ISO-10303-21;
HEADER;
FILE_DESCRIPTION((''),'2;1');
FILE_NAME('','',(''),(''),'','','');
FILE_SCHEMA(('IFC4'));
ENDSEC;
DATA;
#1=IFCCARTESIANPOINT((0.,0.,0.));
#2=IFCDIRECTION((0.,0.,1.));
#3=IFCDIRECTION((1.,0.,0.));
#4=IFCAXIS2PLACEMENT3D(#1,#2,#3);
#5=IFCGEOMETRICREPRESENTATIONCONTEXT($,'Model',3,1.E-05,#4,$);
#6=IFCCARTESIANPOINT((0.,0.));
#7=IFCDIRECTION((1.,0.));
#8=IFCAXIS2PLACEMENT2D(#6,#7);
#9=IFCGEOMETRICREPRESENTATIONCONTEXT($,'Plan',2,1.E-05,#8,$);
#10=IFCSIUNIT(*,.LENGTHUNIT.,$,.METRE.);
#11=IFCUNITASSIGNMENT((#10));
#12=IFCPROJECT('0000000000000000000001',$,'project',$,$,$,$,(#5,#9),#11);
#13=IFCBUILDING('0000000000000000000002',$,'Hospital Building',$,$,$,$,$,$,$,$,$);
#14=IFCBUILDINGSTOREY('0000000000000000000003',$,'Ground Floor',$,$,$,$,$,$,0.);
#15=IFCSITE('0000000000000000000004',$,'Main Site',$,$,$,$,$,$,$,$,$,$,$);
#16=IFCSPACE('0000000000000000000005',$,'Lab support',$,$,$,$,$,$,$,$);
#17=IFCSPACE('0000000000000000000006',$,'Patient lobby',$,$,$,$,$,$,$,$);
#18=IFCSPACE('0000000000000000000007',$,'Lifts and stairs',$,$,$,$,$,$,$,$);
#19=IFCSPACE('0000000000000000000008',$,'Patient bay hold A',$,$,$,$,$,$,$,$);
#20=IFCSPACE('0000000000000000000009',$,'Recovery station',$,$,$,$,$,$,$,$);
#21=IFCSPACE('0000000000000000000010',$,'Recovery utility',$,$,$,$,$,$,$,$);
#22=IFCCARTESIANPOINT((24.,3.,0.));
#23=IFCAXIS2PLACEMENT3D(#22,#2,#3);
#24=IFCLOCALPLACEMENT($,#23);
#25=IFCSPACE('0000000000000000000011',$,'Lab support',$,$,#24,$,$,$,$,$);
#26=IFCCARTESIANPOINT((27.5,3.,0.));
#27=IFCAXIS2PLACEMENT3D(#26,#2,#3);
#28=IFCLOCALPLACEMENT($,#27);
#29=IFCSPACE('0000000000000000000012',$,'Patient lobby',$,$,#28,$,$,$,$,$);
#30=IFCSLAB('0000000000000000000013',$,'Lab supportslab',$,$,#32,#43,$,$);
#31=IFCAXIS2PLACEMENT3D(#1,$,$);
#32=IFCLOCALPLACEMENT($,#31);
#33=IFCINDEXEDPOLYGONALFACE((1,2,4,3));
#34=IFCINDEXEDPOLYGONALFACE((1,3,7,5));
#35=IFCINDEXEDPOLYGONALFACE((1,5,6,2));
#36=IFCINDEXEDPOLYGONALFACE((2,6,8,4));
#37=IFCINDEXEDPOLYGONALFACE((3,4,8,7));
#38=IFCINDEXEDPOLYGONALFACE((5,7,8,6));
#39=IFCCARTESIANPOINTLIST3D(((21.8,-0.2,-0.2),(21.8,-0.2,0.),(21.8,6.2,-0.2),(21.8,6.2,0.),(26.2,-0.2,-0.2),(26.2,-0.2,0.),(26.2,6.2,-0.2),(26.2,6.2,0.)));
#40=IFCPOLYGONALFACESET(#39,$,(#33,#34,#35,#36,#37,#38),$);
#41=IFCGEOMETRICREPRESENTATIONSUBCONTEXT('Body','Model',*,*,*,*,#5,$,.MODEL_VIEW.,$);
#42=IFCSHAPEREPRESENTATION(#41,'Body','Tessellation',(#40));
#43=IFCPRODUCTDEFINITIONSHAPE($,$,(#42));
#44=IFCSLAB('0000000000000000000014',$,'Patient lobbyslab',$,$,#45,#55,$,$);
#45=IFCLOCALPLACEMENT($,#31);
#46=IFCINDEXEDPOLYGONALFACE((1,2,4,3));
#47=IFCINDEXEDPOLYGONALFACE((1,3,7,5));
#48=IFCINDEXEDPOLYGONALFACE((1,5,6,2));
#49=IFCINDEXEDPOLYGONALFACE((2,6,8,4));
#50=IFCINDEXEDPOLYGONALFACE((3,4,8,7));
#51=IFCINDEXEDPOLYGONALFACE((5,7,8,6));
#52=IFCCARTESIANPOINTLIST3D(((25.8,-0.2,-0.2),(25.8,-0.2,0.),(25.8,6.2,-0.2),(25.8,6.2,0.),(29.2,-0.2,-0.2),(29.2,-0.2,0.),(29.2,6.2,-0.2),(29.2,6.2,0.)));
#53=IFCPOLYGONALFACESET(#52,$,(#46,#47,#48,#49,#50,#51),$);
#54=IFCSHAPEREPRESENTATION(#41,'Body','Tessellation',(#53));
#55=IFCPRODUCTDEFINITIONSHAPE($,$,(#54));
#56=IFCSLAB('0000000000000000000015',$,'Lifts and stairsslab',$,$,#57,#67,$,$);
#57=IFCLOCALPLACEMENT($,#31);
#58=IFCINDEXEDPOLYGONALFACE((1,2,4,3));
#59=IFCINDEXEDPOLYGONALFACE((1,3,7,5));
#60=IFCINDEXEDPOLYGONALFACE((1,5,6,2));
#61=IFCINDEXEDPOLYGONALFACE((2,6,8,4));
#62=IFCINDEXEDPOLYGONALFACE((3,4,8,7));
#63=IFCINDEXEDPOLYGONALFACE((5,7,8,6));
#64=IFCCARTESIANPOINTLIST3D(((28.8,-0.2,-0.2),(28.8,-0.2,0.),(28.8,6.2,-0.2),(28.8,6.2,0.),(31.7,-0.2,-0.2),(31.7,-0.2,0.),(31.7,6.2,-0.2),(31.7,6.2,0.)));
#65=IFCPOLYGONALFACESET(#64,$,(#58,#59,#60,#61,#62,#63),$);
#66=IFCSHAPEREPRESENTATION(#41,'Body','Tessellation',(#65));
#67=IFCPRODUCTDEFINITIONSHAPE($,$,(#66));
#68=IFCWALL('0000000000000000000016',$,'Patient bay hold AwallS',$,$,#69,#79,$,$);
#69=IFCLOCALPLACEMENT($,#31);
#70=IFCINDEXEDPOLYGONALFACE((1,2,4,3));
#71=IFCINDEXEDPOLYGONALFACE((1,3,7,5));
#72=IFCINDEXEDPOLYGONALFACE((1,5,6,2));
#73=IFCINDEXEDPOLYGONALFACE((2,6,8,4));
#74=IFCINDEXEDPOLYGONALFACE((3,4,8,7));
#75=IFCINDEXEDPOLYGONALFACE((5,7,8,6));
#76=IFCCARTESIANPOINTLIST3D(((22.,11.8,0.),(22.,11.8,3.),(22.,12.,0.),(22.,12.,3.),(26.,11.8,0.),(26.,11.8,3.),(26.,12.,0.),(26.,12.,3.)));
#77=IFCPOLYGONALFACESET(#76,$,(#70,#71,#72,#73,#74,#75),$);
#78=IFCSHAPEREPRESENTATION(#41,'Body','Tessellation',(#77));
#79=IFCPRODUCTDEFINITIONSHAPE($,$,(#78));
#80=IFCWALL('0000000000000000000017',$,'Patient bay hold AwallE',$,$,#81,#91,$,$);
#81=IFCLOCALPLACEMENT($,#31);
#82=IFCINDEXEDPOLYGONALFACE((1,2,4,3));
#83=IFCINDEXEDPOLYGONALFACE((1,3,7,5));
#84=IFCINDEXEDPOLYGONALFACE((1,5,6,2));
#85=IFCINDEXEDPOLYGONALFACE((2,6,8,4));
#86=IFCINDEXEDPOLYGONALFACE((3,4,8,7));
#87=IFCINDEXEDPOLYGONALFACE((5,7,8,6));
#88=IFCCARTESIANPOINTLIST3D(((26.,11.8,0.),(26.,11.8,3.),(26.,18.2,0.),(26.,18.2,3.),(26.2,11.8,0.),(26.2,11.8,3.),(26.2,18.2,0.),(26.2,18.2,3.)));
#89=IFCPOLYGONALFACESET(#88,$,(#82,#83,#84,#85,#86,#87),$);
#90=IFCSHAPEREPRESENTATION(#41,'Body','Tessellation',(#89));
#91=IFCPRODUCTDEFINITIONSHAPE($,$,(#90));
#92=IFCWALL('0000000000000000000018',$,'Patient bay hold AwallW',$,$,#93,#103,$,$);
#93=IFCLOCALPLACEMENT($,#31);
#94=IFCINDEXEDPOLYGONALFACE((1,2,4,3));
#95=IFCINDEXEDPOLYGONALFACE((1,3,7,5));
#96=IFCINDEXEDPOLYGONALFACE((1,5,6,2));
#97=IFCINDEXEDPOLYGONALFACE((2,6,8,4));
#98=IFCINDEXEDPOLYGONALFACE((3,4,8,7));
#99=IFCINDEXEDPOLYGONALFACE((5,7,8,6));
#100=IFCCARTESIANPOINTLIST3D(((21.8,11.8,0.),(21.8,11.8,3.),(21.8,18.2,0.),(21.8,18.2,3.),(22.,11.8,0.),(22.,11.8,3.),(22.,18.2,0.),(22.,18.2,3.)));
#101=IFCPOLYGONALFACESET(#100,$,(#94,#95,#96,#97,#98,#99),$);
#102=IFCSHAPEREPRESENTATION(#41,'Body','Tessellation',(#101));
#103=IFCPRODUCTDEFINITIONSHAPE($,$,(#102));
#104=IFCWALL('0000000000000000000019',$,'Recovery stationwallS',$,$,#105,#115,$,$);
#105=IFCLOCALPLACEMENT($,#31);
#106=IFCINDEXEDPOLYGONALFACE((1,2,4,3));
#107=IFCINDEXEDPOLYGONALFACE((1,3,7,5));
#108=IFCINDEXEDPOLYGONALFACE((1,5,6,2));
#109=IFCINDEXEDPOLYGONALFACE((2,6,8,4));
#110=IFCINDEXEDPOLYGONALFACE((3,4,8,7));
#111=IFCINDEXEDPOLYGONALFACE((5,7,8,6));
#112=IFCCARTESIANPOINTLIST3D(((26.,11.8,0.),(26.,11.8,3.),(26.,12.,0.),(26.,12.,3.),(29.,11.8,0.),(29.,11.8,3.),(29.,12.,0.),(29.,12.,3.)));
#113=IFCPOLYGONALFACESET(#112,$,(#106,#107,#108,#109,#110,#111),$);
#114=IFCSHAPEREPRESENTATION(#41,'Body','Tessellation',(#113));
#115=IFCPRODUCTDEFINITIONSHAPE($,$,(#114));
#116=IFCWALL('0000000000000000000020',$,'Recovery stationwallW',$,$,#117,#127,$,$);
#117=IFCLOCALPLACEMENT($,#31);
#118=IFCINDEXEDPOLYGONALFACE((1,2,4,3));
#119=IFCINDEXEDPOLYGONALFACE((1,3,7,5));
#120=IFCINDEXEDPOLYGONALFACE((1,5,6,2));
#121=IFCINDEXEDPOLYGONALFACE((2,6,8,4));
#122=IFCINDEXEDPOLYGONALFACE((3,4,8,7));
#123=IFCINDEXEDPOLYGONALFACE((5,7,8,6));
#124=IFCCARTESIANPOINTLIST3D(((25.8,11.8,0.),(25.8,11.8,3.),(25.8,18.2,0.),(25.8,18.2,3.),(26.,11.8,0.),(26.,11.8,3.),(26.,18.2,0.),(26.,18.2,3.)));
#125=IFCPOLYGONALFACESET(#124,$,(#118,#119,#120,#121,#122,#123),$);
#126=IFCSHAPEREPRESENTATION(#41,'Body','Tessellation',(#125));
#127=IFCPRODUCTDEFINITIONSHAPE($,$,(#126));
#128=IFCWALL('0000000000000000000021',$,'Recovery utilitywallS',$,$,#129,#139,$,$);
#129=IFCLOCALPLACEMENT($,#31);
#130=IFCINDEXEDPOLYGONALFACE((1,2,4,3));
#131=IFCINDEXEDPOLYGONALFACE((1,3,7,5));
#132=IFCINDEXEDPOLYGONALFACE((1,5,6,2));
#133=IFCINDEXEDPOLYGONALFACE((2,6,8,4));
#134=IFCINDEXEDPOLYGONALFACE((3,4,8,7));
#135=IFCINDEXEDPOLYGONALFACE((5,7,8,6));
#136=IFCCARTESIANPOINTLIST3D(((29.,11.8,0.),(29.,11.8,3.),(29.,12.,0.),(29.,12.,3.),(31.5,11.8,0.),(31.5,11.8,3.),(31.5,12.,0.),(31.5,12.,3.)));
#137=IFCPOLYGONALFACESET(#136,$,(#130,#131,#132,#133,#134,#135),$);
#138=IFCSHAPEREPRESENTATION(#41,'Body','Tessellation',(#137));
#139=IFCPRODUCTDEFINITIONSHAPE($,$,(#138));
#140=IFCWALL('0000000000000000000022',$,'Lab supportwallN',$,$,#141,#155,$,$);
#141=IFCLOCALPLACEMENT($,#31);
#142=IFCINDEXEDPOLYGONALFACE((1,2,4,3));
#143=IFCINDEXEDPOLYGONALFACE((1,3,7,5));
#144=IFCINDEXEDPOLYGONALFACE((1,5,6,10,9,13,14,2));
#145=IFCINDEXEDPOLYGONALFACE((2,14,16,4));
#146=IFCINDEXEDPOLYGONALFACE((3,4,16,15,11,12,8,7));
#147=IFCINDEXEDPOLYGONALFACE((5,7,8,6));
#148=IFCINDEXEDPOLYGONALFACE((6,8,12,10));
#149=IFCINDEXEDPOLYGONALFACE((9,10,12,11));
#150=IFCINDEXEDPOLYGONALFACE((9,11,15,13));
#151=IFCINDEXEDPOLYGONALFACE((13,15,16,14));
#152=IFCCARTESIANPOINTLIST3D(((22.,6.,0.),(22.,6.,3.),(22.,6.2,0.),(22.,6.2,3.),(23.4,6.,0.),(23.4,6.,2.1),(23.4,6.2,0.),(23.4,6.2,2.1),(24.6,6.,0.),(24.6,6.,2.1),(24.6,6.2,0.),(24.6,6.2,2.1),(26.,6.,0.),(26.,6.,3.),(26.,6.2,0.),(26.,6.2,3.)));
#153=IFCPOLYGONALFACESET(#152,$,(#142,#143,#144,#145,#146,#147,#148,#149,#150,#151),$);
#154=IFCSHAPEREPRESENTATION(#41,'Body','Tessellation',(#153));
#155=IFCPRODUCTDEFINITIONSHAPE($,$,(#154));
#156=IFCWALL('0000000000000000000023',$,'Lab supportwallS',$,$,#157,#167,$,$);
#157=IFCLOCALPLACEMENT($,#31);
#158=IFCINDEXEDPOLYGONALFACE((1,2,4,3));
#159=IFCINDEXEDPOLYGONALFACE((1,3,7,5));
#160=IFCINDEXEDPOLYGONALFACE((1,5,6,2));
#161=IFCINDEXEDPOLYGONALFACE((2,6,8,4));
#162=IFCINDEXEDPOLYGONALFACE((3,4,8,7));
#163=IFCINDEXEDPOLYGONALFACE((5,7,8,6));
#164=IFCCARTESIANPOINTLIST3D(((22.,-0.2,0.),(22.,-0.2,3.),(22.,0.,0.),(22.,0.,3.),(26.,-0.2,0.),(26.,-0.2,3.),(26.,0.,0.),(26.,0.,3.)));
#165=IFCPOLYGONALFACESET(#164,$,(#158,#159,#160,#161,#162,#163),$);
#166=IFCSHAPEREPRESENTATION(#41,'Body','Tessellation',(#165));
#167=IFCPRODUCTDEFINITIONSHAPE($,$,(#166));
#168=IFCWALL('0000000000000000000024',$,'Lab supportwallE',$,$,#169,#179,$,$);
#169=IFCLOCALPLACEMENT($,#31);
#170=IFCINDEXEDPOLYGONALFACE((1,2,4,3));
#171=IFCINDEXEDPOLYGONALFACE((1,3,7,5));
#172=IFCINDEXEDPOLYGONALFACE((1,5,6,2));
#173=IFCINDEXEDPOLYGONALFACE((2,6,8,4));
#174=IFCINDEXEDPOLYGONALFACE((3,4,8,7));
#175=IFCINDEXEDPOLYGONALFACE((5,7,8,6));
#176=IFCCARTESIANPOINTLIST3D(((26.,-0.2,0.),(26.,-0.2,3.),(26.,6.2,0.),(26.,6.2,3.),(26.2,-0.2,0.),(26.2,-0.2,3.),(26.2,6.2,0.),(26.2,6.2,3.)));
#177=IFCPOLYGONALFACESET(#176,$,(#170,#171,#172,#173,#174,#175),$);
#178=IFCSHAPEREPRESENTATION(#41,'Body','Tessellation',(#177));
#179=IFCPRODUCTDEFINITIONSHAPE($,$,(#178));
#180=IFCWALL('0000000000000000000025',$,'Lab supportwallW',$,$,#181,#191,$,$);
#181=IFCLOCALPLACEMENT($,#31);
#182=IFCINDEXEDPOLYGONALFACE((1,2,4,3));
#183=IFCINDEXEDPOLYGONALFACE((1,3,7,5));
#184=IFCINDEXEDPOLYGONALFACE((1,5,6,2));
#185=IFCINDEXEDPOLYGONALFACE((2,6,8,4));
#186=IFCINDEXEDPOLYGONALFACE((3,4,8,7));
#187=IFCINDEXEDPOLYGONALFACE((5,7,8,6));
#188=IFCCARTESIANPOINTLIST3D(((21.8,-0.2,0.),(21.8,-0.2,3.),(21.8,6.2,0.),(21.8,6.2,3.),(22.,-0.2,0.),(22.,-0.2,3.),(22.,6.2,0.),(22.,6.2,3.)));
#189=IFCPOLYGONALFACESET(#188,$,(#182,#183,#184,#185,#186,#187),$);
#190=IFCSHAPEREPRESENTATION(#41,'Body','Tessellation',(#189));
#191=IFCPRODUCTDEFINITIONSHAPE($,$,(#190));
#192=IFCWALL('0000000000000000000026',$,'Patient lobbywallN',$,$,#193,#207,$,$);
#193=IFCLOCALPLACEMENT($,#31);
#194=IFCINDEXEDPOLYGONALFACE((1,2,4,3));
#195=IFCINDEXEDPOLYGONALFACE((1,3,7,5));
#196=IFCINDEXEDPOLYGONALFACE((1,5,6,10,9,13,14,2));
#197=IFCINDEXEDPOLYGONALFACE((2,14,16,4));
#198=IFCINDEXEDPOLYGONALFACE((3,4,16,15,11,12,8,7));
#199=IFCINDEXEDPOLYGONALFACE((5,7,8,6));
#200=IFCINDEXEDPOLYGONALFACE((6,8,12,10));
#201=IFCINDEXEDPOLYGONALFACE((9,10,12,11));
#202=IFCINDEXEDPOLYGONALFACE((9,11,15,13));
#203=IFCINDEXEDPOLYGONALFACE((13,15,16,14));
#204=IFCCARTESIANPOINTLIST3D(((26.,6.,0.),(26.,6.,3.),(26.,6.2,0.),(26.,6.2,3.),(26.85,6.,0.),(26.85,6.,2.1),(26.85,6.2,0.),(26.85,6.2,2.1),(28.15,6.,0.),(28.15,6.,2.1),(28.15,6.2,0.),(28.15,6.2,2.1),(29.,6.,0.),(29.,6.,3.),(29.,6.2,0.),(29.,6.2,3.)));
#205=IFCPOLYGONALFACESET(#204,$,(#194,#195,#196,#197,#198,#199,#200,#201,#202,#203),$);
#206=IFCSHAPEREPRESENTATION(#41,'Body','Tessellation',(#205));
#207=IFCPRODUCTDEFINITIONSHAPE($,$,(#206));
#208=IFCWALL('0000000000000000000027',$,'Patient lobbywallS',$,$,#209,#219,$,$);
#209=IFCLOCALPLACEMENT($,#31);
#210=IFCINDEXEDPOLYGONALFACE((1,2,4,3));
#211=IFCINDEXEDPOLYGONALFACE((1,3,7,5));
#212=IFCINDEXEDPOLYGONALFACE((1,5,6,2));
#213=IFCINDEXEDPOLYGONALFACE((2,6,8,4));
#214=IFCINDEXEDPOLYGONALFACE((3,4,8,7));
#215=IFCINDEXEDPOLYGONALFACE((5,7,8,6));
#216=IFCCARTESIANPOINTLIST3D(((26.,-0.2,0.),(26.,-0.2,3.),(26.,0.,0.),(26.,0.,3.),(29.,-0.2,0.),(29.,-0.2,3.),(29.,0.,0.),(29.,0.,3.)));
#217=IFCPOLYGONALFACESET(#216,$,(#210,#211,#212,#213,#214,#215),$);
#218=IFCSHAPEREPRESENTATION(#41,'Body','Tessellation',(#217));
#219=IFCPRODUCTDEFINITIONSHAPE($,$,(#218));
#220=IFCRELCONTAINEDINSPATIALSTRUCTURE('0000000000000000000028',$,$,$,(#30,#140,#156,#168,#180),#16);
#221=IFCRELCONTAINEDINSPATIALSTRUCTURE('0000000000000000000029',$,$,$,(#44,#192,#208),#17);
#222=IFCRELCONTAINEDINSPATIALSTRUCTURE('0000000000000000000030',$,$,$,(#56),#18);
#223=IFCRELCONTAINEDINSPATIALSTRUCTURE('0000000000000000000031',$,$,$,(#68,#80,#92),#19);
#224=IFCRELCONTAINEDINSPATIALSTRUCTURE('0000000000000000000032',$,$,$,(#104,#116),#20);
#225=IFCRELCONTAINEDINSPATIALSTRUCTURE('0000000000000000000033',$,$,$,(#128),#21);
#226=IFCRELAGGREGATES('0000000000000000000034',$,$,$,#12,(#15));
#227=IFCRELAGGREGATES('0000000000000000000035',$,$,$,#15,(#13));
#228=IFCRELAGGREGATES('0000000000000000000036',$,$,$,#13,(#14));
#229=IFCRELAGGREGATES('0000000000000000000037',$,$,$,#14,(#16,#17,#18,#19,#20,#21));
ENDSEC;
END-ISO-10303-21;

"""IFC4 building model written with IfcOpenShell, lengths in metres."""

from ifc_helpers import new_model, si_unit, frame, origin_with_axes, origin_2d_with_axis, place, context, subcontext, project, spatial, indexed_curve, rectangle, outline, extrude, element, save


model = new_model("IFC4")

# Units and contexts
model_context = context("Model", 3, precision=1e-05, world=origin_with_axes())
plan_context = context("Plan", 2, precision=1e-05, world=origin_2d_with_axis())
body_context = subcontext(model_context, "Body", "Model", "MODEL_VIEW")
ifc_project = project(units=[si_unit("LENGTHUNIT", "METRE")], contexts=[model_context, plan_context])

# Site, building, storey, space
site = spatial("IfcSite", under=ifc_project, Name="Main Site")
building = spatial("IfcBuilding", under=site, Name="Hospital Building")
storey = spatial("IfcBuildingStorey", under=building, Name="Ground Floor", Elevation=0.0)
space_1 = spatial("IfcSpace", under=storey, Name="Lab support")

# Slab
slab_1_placement = place(None, frame((24.0, 3.0, -0.2), z_axis=(0.0, 0.0, 1.0), x_axis=(1.0, 0.0, 0.0)))
element("IfcSlab", 1, at=slab_1_placement, inside=space_1, Name="Lab supportslab", context=body_context, shape_type="SweptSolid", body=[
    extrude(rectangle(XDim=4.4, YDim=6.4), origin_with_axes(), (0.0, 0.0, 1.0), 0.2),
])

# Shared definitions
space_2 = spatial("IfcSpace", under=storey, Name="Patient lobby")

# Slab
slab_2_placement = place(None, frame((27.5, 3.0, -0.2), z_axis=(0.0, 0.0, 1.0), x_axis=(1.0, 0.0, 0.0)))
element("IfcSlab", 2, at=slab_2_placement, inside=space_2, Name="Patient lobbyslab", context=body_context, shape_type="SweptSolid", body=[
    extrude(rectangle(XDim=3.4, YDim=6.4), origin_with_axes(), (0.0, 0.0, 1.0), 0.2),
])

# Shared definitions
space_3 = spatial("IfcSpace", under=storey, Name="Lifts and stairs")

# Slab
slab_3_placement = place(None, frame((30.25, 3.0, -0.2), z_axis=(0.0, 0.0, 1.0), x_axis=(1.0, 0.0, 0.0)))
element("IfcSlab", 3, at=slab_3_placement, inside=space_3, Name="Lifts and stairsslab", context=body_context, shape_type="SweptSolid", body=[
    extrude(rectangle(XDim=2.9, YDim=6.4), origin_with_axes(), (0.0, 0.0, 1.0), 0.2),
])

# Shared definitions
space_4 = spatial("IfcSpace", under=storey, Name="Patient bay hold A")

# Walls
wall_1_placement = place(None, frame((22.0, 11.8, 0.0), z_axis=(0.0, 0.0, 1.0), x_axis=(1.0, 0.0, 0.0)))
element("IfcWall", 4, at=wall_1_placement, inside=space_4, Name="Patient bay hold AwallS", context=body_context, shape_type="SweptSolid", body=[
    extrude(outline(indexed_curve([(0.0, 0.0), (0.0, 0.2), (4.0, 0.2), (4.0, 0.0), (0.0, 0.0)], self_intersect=False)), origin_with_axes(), (0.0, 0.0, 1.0), 3.0),
])
for number, where, z_axis, x_axis, name in (
    (5, (26.2, 11.8, 0.0), (0.0, 0.0, 1.0), (0.0, 1.0, 0.0), "Patient bay hold AwallE"),
    (6, (22.0, 11.8, 0.0), (0.0, 0.0, 1.0), (0.0, 1.0, 0.0), "Patient bay hold AwallW"),
):
    element("IfcWall", number, at=place(None, frame(where, z_axis=z_axis, x_axis=x_axis)), inside=space_4, Name=name, context=body_context, shape_type="SweptSolid", body=[
        extrude(outline(indexed_curve([(0.0, 0.0), (0.0, 0.2), (6.4, 0.2), (6.4, 0.0), (0.0, 0.0)], self_intersect=False)), origin_with_axes(), (0.0, 0.0, 1.0), 3.0),
    ])

# Shared definitions
space_5 = spatial("IfcSpace", under=storey, Name="Recovery station")

# Walls
wall_2_placement = place(None, frame((26.0, 11.8, 0.0), z_axis=(0.0, 0.0, 1.0), x_axis=(1.0, 0.0, 0.0)))
element("IfcWall", 7, at=wall_2_placement, inside=space_5, Name="Recovery stationwallS", context=body_context, shape_type="SweptSolid", body=[
    extrude(outline(indexed_curve([(0.0, 0.0), (0.0, 0.2), (3.0, 0.2), (3.0, 0.0), (0.0, 0.0)], self_intersect=False)), origin_with_axes(), (0.0, 0.0, 1.0), 3.0),
])
wall_3_placement = place(None, frame((26.0, 11.8, 0.0), z_axis=(0.0, 0.0, 1.0), x_axis=(0.0, 1.0, 0.0)))
element("IfcWall", 8, at=wall_3_placement, inside=space_5, Name="Recovery stationwallW", context=body_context, shape_type="SweptSolid", body=[
    extrude(outline(indexed_curve([(0.0, 0.0), (0.0, 0.2), (6.4, 0.2), (6.4, 0.0), (0.0, 0.0)], self_intersect=False)), origin_with_axes(), (0.0, 0.0, 1.0), 3.0),
])

# Shared definitions
space_6 = spatial("IfcSpace", under=storey, Name="Recovery utility")

# Walls
wall_4_placement = place(None, frame((29.0, 11.8, 0.0), z_axis=(0.0, 0.0, 1.0), x_axis=(1.0, 0.0, 0.0)))
element("IfcWall", 9, at=wall_4_placement, inside=space_6, Name="Recovery utilitywallS", context=body_context, shape_type="SweptSolid", body=[
    extrude(outline(indexed_curve([(0.0, 0.0), (0.0, 0.2), (2.5, 0.2), (2.5, 0.0), (0.0, 0.0)], self_intersect=False)), origin_with_axes(), (0.0, 0.0, 1.0), 3.0),
])
wall_5_placement = place(None, frame((22.0, 6.0, 0.0), z_axis=(0.0, 0.0, 1.0), x_axis=(1.0, 0.0, 0.0)))
wall_5 = element("IfcWall", 10, at=wall_5_placement, inside=space_1, Name="Lab supportwallN", context=body_context, shape_type="SweptSolid", body=[
    extrude(outline(indexed_curve([(0.0, 0.0), (0.0, 0.2), (4.0, 0.2), (4.0, 0.0), (0.0, 0.0)], self_intersect=False)), origin_with_axes(), (0.0, 0.0, 1.0), 3.0),
])

# Shared definitions
space_7_placement = place(None, frame((24.0, 3.0, 0.0), z_axis=(0.0, 0.0, 1.0), x_axis=(1.0, 0.0, 0.0)))
space_7 = spatial("IfcSpace", at=space_7_placement, Name="Lab support")

# Opening
opening_1_placement = place(wall_5_placement, frame((1.4, -0.1, 0.0), z_axis=(0.0, 0.0, 1.0), x_axis=(1.0, 0.0, 0.0)))
element("IfcOpeningElement", 11, at=opening_1_placement, inside=space_7, cuts=wall_5, context=body_context, shape_type="SweptSolid", body=[
    extrude(outline(indexed_curve([(0.0, 0.0), (0.0, 0.4), (1.2, 0.4), (1.2, 0.0), (0.0, 0.0)], self_intersect=False)), origin_with_axes(), (0.0, 0.0, 1.0), 2.1),
])

# Walls
wall_6_placement = place(None, frame((22.0, -0.2, 0.0), z_axis=(0.0, 0.0, 1.0), x_axis=(1.0, 0.0, 0.0)))
element("IfcWall", 12, at=wall_6_placement, inside=space_1, Name="Lab supportwallS", context=body_context, shape_type="SweptSolid", body=[
    extrude(outline(indexed_curve([(0.0, 0.0), (0.0, 0.2), (4.0, 0.2), (4.0, 0.0), (0.0, 0.0)], self_intersect=False)), origin_with_axes(), (0.0, 0.0, 1.0), 3.0),
])
for number, where, z_axis, x_axis, name in (
    (13, (26.2, -0.2, 0.0), (0.0, 0.0, 1.0), (0.0, 1.0, 0.0), "Lab supportwallE"),
    (14, (22.0, -0.2, 0.0), (0.0, 0.0, 1.0), (0.0, 1.0, 0.0), "Lab supportwallW"),
):
    element("IfcWall", number, at=place(None, frame(where, z_axis=z_axis, x_axis=x_axis)), inside=space_1, Name=name, context=body_context, shape_type="SweptSolid", body=[
        extrude(outline(indexed_curve([(0.0, 0.0), (0.0, 0.2), (6.4, 0.2), (6.4, 0.0), (0.0, 0.0)], self_intersect=False)), origin_with_axes(), (0.0, 0.0, 1.0), 3.0),
    ])

# Wall
wall_7_placement = place(None, frame((26.0, 6.0, 0.0), z_axis=(0.0, 0.0, 1.0), x_axis=(1.0, 0.0, 0.0)))
wall_7 = element("IfcWall", 15, at=wall_7_placement, inside=space_2, Name="Patient lobbywallN", context=body_context, shape_type="SweptSolid", body=[
    extrude(outline(indexed_curve([(0.0, 0.0), (0.0, 0.2), (3.0, 0.2), (3.0, 0.0), (0.0, 0.0)], self_intersect=False)), origin_with_axes(), (0.0, 0.0, 1.0), 3.0),
])

# Shared definitions
space_8_placement = place(None, frame((27.5, 3.0, 0.0), z_axis=(0.0, 0.0, 1.0), x_axis=(1.0, 0.0, 0.0)))
space_8 = spatial("IfcSpace", at=space_8_placement, Name="Patient lobby")

# Opening
opening_2_placement = place(wall_7_placement, frame((0.85, -0.1, 0.0), z_axis=(0.0, 0.0, 1.0), x_axis=(1.0, 0.0, 0.0)))
element("IfcOpeningElement", 16, at=opening_2_placement, inside=space_8, cuts=wall_7, context=body_context, shape_type="SweptSolid", body=[
    extrude(outline(indexed_curve([(0.0, 0.0), (0.0, 0.4), (1.3, 0.4), (1.3, 0.0), (0.0, 0.0)], self_intersect=False)), origin_with_axes(), (0.0, 0.0, 1.0), 2.1),
])

# Wall
wall_8_placement = place(None, frame((26.0, -0.2, 0.0), z_axis=(0.0, 0.0, 1.0), x_axis=(1.0, 0.0, 0.0)))
element("IfcWall", 17, at=wall_8_placement, inside=space_2, Name="Patient lobbywallS", context=body_context, shape_type="SweptSolid", body=[
    extrude(outline(indexed_curve([(0.0, 0.0), (0.0, 0.2), (3.0, 0.2), (3.0, 0.0), (0.0, 0.0)], self_intersect=False)), origin_with_axes(), (0.0, 0.0, 1.0), 3.0),
])

save(model, "model.ifc")
